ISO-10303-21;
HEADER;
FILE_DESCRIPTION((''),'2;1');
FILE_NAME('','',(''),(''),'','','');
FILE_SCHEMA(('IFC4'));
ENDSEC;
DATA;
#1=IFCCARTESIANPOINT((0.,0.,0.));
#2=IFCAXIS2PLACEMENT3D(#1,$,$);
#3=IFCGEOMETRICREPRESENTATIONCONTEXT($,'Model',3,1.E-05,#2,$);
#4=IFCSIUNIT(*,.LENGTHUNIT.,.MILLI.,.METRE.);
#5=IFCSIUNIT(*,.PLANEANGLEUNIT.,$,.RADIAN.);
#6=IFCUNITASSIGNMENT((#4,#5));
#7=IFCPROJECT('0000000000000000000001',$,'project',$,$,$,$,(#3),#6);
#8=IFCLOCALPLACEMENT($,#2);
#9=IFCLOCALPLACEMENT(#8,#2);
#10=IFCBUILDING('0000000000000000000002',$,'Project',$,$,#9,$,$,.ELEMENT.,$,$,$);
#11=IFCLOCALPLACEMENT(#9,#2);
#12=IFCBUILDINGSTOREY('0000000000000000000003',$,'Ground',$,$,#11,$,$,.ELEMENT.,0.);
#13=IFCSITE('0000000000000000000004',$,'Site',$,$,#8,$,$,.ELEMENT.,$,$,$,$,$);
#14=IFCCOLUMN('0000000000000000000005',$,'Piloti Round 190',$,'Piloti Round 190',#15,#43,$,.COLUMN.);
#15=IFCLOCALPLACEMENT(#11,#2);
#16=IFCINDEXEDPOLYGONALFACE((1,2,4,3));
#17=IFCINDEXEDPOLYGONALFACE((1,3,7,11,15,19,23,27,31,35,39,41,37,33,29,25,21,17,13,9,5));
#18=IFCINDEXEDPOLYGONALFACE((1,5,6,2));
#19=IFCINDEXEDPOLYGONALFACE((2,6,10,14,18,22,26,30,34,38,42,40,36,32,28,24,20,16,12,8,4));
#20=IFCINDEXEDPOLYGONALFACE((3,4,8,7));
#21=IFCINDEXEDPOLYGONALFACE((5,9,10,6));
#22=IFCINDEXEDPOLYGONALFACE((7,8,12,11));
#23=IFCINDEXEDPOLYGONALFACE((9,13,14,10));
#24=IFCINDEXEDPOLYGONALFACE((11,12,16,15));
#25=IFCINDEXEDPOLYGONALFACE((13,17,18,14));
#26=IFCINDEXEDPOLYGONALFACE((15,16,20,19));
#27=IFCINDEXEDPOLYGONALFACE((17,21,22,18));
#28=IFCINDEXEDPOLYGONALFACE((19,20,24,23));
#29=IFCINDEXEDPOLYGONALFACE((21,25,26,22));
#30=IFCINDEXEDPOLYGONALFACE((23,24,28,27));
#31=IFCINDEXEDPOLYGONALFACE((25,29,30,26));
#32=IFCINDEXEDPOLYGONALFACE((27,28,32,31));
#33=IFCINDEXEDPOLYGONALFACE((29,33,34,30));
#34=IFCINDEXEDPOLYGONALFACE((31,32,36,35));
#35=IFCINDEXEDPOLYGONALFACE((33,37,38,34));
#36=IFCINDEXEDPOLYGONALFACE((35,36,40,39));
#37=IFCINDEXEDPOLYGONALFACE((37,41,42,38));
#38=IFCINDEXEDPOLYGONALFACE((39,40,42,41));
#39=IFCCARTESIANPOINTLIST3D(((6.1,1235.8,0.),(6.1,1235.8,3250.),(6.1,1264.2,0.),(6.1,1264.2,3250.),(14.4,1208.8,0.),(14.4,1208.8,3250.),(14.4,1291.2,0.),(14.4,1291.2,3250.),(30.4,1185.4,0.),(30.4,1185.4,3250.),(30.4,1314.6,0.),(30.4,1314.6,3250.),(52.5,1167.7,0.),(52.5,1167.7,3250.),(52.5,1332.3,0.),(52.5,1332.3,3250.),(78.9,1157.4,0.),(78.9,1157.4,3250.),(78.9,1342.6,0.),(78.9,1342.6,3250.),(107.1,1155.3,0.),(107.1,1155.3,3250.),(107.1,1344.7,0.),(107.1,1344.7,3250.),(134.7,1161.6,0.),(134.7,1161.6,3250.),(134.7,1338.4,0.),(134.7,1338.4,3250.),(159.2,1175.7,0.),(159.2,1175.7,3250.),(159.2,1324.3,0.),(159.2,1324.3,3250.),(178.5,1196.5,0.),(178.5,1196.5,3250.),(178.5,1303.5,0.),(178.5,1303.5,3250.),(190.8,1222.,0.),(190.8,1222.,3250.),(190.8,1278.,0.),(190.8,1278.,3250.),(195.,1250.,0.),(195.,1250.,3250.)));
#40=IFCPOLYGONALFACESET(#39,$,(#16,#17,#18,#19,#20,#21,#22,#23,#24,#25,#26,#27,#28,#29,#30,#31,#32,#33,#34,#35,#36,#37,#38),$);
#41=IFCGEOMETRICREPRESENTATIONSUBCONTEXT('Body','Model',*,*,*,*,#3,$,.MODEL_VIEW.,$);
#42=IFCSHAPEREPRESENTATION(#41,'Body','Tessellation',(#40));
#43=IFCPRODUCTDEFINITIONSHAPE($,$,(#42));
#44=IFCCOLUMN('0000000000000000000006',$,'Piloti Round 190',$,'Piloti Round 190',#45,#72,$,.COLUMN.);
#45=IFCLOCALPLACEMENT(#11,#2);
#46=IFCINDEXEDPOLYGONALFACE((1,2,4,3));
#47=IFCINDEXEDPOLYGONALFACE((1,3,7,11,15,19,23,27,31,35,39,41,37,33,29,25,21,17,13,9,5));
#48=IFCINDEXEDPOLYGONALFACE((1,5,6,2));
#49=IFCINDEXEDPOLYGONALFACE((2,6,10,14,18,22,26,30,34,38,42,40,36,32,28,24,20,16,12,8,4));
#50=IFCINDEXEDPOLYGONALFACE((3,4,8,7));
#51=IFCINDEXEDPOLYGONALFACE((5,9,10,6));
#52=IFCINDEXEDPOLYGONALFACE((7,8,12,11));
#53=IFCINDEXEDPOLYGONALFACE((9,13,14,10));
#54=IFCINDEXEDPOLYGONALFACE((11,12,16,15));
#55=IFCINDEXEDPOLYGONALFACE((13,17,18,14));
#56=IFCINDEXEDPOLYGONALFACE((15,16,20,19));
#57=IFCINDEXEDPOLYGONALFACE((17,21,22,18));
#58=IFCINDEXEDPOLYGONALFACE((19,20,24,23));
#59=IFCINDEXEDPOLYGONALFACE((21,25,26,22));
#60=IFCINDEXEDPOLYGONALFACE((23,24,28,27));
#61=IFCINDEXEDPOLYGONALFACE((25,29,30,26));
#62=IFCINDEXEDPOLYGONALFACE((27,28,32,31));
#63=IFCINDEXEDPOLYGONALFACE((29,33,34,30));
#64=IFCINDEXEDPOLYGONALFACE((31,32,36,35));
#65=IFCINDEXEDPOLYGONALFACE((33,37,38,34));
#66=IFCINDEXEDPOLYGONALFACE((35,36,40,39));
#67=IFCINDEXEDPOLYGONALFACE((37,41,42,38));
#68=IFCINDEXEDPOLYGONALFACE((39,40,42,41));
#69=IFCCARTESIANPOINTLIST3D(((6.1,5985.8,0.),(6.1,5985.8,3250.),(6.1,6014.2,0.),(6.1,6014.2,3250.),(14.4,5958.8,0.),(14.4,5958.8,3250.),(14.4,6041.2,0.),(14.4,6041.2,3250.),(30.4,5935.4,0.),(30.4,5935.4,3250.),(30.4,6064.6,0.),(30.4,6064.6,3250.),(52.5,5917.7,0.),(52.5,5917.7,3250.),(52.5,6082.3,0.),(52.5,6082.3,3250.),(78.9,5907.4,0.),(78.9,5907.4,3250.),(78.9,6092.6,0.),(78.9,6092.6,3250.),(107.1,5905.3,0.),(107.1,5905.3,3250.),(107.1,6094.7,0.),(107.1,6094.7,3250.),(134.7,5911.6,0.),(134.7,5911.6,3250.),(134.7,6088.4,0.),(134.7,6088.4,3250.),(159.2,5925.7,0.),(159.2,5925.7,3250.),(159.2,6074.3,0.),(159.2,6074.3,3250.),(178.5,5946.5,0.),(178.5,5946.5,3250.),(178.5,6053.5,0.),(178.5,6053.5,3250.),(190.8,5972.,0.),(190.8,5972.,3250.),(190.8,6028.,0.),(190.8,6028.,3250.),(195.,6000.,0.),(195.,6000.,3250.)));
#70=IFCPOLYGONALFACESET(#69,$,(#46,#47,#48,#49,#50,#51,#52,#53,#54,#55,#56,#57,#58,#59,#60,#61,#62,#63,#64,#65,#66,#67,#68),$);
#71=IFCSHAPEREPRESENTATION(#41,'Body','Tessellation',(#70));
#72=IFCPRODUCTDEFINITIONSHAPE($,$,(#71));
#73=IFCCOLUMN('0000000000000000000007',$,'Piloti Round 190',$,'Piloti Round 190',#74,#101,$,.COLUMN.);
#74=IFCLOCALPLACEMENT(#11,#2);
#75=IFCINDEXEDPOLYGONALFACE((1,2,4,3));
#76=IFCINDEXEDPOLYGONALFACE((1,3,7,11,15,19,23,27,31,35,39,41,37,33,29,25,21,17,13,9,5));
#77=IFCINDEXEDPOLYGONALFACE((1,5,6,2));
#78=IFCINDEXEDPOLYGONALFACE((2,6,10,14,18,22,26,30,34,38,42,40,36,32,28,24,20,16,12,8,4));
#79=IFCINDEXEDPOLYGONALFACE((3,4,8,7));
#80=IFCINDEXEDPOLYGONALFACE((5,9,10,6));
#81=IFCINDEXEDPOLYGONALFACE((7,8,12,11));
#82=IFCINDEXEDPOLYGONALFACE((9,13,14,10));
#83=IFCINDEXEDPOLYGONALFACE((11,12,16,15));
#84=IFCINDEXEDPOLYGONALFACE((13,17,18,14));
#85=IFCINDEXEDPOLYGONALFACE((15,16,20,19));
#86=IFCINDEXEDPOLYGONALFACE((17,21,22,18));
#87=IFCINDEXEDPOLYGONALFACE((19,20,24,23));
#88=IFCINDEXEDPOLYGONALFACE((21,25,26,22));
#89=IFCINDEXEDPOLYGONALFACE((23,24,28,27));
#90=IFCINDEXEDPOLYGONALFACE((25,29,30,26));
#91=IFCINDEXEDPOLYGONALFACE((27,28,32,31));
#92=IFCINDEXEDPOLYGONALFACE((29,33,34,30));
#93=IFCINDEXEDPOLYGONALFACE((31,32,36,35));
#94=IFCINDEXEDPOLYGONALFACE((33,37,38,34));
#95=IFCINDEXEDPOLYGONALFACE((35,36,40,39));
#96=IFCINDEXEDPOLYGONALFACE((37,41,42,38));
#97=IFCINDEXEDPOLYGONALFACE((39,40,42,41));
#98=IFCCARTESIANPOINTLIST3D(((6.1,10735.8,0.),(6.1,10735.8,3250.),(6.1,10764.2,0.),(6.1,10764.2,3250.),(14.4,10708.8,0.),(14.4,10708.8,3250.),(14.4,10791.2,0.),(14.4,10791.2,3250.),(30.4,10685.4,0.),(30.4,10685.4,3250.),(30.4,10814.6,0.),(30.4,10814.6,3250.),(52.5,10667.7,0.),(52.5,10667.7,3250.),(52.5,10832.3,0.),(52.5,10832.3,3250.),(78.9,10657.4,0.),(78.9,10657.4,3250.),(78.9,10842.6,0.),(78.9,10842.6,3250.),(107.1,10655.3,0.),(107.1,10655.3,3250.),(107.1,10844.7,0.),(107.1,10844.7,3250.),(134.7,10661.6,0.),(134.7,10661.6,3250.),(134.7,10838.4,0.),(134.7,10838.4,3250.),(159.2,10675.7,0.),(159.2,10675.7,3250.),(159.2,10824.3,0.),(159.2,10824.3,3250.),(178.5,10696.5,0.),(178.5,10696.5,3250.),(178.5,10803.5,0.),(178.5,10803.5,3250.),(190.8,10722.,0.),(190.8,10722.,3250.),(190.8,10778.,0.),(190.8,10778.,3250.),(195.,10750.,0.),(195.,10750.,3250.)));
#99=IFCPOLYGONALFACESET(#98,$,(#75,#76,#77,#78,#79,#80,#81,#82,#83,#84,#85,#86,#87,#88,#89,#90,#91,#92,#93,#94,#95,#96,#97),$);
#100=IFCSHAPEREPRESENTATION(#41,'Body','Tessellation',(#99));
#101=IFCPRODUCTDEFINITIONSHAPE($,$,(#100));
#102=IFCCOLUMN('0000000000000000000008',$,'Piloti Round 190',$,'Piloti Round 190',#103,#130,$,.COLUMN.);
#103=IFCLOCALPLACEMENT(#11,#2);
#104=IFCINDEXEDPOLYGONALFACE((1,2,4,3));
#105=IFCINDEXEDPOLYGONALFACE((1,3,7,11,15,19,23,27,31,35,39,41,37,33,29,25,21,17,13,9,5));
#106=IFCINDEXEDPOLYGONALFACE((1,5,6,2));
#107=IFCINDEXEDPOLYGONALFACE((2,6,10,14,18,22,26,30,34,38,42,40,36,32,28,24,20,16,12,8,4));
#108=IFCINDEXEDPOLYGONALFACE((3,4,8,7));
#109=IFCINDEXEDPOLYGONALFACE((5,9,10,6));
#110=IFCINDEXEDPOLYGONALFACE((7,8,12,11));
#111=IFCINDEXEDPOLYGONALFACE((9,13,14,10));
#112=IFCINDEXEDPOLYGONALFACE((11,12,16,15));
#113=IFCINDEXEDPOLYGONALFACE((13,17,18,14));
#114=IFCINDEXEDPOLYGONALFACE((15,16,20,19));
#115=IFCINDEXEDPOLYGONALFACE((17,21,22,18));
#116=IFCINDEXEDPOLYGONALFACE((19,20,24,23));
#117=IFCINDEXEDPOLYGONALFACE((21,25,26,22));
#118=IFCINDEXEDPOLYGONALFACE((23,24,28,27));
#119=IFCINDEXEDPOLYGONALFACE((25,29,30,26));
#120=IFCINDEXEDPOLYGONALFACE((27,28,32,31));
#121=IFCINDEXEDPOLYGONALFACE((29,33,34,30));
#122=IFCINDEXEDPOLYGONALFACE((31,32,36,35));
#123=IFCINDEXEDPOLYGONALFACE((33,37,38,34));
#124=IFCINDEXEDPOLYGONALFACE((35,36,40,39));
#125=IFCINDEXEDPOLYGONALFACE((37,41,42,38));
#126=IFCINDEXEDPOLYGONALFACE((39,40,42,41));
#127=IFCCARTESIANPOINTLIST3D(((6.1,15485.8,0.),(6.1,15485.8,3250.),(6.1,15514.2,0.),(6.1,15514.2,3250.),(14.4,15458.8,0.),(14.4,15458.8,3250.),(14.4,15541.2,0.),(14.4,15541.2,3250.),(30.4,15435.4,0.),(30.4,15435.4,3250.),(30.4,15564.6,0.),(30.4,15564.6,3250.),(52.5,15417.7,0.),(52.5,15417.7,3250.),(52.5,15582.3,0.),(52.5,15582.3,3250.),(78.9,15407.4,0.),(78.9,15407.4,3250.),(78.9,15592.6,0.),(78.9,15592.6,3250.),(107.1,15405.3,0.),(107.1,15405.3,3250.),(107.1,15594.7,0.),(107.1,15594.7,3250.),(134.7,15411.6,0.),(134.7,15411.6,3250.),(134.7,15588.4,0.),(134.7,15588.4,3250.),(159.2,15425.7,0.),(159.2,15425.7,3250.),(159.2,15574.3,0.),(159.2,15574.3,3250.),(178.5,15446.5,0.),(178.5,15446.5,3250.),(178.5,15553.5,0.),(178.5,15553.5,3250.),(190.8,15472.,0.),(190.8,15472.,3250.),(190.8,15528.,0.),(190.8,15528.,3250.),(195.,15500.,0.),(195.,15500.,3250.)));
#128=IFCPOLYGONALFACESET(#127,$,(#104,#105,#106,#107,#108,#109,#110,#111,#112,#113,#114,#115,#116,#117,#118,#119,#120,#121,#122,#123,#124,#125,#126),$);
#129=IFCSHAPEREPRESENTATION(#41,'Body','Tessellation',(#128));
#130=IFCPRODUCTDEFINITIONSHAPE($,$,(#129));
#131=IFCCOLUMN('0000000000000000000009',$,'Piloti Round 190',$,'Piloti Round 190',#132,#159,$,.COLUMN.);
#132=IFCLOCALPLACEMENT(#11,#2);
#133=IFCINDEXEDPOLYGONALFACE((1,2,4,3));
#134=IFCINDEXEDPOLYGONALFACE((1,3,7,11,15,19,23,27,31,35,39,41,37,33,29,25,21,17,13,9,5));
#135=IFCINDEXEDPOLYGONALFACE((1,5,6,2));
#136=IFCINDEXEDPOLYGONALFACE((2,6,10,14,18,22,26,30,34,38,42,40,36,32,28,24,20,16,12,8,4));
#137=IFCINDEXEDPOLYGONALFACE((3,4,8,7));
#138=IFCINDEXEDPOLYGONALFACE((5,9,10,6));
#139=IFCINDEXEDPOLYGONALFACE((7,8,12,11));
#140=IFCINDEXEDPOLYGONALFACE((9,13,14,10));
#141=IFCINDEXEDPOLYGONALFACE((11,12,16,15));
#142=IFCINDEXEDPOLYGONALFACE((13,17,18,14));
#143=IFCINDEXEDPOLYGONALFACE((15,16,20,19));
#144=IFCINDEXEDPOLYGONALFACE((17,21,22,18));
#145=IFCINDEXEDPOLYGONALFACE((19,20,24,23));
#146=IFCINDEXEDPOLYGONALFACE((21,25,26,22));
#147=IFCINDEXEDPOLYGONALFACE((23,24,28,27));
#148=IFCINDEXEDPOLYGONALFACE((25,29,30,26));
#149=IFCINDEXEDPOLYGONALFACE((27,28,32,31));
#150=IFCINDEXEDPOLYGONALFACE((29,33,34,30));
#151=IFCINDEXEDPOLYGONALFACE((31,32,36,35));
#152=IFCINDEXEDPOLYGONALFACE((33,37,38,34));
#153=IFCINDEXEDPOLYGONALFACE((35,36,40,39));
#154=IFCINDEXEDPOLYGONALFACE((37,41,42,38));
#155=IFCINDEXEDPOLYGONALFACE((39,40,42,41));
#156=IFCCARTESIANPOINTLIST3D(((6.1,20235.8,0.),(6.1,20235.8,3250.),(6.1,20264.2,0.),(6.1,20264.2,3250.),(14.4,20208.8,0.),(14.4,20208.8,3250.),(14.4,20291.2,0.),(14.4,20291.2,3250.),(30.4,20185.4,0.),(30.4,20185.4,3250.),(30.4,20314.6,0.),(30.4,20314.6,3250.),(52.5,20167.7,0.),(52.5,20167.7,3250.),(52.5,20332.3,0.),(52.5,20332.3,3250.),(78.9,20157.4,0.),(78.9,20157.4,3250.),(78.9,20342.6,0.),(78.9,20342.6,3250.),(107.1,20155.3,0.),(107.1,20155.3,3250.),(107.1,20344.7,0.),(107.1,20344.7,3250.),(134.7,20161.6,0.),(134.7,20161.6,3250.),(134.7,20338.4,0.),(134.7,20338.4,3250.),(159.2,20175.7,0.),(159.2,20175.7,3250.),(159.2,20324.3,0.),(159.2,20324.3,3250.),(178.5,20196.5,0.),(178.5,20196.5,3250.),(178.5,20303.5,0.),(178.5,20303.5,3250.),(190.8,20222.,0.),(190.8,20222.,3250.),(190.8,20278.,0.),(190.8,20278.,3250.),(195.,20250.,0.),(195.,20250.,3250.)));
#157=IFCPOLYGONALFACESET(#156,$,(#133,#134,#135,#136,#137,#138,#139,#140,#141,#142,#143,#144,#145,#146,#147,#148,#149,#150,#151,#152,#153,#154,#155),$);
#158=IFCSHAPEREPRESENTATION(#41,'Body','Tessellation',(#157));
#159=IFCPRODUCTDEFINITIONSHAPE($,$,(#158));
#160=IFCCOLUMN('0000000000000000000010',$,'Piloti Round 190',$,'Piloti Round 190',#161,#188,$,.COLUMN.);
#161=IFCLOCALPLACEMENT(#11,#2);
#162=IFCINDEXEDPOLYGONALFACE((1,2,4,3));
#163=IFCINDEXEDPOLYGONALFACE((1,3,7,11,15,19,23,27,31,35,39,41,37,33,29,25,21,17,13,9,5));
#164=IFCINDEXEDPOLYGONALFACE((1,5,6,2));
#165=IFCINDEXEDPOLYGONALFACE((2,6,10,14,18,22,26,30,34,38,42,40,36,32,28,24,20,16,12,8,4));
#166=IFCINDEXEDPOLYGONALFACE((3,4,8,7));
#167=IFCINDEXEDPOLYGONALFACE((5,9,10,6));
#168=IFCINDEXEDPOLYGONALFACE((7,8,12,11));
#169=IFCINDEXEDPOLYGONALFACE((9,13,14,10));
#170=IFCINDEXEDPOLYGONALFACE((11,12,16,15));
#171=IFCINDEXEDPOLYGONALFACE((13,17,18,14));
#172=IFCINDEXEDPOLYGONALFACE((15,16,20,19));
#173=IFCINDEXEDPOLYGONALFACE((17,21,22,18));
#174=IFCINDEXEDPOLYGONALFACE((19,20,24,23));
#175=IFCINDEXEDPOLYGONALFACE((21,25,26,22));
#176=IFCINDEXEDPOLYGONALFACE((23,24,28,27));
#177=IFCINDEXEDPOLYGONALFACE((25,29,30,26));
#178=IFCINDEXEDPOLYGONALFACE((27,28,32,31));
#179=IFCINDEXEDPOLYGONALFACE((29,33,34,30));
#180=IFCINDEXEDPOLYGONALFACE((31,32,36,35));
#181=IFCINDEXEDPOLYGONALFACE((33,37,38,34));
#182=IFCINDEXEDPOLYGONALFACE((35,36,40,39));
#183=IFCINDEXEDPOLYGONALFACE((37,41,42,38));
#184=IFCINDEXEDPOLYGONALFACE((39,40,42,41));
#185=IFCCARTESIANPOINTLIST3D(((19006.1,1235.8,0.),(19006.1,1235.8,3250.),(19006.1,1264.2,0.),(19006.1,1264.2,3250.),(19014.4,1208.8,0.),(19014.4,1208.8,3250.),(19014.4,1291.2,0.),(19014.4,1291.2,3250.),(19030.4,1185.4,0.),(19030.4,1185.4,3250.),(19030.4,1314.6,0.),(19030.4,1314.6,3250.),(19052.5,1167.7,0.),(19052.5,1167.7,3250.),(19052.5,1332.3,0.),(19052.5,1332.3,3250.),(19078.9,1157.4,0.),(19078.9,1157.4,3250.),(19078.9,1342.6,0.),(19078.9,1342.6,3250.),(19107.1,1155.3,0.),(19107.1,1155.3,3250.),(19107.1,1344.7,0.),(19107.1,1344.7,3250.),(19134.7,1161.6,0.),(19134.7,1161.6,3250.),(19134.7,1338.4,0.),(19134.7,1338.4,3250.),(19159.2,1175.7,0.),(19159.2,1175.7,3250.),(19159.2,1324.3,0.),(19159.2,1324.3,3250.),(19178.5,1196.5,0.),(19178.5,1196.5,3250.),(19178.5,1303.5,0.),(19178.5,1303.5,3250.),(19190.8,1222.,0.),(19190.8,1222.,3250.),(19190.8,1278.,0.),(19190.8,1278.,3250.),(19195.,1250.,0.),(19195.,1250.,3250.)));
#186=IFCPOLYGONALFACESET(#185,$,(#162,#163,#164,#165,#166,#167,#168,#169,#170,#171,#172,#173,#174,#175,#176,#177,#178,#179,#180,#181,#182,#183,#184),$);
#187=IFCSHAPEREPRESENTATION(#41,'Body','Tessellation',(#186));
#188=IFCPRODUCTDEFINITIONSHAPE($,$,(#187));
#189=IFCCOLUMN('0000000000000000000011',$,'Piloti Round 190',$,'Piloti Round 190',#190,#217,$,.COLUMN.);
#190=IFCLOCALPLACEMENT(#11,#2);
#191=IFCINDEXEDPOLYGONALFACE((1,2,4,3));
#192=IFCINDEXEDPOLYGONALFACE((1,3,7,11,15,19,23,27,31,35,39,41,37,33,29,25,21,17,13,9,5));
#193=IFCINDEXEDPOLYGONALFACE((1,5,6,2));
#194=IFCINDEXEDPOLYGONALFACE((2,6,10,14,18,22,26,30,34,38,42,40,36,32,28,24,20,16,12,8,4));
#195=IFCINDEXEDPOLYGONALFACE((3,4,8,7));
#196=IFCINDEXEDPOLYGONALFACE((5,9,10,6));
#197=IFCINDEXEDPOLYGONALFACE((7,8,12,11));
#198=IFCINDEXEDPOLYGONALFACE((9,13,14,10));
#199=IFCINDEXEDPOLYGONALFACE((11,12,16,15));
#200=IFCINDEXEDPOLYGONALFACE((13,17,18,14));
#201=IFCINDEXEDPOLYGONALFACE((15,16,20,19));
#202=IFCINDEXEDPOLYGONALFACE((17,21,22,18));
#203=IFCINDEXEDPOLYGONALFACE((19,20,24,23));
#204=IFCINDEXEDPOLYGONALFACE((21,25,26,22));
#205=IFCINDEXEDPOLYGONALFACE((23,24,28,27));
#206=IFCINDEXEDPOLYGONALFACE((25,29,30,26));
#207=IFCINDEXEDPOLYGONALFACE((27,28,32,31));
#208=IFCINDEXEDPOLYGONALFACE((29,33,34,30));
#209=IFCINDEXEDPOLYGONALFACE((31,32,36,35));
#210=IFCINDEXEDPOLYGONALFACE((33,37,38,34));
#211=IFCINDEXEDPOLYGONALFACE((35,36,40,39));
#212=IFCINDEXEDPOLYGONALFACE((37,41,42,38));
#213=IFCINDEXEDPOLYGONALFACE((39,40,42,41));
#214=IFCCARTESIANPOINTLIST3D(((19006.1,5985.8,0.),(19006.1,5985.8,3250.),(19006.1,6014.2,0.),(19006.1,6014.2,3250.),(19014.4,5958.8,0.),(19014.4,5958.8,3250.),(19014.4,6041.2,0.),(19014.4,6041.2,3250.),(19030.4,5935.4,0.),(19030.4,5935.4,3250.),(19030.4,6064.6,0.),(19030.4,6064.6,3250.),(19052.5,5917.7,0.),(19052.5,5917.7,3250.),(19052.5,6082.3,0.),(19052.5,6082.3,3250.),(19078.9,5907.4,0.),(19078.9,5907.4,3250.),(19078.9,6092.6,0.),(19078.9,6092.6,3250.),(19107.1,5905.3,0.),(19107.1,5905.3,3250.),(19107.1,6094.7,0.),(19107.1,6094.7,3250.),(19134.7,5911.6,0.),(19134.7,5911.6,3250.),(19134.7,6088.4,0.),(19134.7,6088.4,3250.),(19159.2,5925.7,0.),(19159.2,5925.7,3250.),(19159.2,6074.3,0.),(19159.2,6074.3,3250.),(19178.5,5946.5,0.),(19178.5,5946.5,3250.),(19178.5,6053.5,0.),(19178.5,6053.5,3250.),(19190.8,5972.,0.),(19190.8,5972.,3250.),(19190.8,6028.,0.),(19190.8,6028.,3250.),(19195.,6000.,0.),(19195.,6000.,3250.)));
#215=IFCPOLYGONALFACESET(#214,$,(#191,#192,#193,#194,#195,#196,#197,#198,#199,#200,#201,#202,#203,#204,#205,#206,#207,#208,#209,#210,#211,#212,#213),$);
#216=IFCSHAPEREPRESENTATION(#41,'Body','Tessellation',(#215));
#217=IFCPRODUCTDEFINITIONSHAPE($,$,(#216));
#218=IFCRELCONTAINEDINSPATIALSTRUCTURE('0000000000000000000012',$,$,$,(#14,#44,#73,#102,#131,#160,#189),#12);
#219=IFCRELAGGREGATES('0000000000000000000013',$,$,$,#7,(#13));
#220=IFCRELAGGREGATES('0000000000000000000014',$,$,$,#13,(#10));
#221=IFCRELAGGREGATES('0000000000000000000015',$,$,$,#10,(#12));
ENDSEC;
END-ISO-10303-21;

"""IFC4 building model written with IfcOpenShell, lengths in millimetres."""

from ifc_helpers import new_model, si_unit, frame, origin, origin_2d, place, context, subcontext, project, spatial, circle, extrude, element, save


model = new_model("IFC4")

# Units and contexts
model_context = context("Model", 3, precision=1e-05, world=origin())
body_context = subcontext(model_context, "Body", "Model", "MODEL_VIEW")
ifc_project = project(units=[si_unit("LENGTHUNIT", "METRE", prefix="MILLI"), si_unit("PLANEANGLEUNIT", "RADIAN")], contexts=[model_context])

# Site, building, storey
site_placement = place(None, origin())
site = spatial("IfcSite", under=ifc_project, at=site_placement, Name="Site", CompositionType="ELEMENT")
building_placement = place(site_placement, origin())
building = spatial("IfcBuilding", under=site, at=building_placement, Name="Project", CompositionType="ELEMENT")
storey_placement = place(building_placement, origin())
storey = spatial("IfcBuildingStorey", under=building, at=storey_placement, Name="Ground", CompositionType="ELEMENT", Elevation=0.0)

# Columns
for number, where, z_axis, x_axis, name in (
    (1, (100.0, 1250.0, 0.0), (0.0, 0.0, 1.0), (1.0, 0.0, 0.0), "Piloti Round 190"),
    (2, (100.0, 6000.0, 0.0), (0.0, 0.0, 1.0), (1.0, 0.0, 0.0), "Piloti Round 190"),
    (3, (100.0, 10750.0, 0.0), (0.0, 0.0, 1.0), (1.0, 0.0, 0.0), "Piloti Round 190"),
    (4, (100.0, 15500.0, 0.0), (0.0, 0.0, 1.0), (1.0, 0.0, 0.0), "Piloti Round 190"),
    (5, (100.0, 20250.0, 0.0), (0.0, 0.0, 1.0), (1.0, 0.0, 0.0), "Piloti Round 190"),
    (6, (19100.0, 1250.0, 0.0), (0.0, 0.0, 1.0), (1.0, 0.0, 0.0), "Piloti Round 190"),
    (7, (19100.0, 6000.0, 0.0), (0.0, 0.0, 1.0), (1.0, 0.0, 0.0), "Piloti Round 190"),
):
    element("IfcColumn", number, at=place(storey_placement, frame(where, z_axis=z_axis, x_axis=x_axis)), inside=storey, Name=name, ObjectType="Piloti Round 190", PredefinedType="COLUMN", context=body_context, shape_type="SweptSolid", body=[
        extrude(circle(Radius=95.0, at=origin_2d()), origin(), (0.0, 0.0, 1.0), 3250.0),
    ])

save(model, "model.ifc")
